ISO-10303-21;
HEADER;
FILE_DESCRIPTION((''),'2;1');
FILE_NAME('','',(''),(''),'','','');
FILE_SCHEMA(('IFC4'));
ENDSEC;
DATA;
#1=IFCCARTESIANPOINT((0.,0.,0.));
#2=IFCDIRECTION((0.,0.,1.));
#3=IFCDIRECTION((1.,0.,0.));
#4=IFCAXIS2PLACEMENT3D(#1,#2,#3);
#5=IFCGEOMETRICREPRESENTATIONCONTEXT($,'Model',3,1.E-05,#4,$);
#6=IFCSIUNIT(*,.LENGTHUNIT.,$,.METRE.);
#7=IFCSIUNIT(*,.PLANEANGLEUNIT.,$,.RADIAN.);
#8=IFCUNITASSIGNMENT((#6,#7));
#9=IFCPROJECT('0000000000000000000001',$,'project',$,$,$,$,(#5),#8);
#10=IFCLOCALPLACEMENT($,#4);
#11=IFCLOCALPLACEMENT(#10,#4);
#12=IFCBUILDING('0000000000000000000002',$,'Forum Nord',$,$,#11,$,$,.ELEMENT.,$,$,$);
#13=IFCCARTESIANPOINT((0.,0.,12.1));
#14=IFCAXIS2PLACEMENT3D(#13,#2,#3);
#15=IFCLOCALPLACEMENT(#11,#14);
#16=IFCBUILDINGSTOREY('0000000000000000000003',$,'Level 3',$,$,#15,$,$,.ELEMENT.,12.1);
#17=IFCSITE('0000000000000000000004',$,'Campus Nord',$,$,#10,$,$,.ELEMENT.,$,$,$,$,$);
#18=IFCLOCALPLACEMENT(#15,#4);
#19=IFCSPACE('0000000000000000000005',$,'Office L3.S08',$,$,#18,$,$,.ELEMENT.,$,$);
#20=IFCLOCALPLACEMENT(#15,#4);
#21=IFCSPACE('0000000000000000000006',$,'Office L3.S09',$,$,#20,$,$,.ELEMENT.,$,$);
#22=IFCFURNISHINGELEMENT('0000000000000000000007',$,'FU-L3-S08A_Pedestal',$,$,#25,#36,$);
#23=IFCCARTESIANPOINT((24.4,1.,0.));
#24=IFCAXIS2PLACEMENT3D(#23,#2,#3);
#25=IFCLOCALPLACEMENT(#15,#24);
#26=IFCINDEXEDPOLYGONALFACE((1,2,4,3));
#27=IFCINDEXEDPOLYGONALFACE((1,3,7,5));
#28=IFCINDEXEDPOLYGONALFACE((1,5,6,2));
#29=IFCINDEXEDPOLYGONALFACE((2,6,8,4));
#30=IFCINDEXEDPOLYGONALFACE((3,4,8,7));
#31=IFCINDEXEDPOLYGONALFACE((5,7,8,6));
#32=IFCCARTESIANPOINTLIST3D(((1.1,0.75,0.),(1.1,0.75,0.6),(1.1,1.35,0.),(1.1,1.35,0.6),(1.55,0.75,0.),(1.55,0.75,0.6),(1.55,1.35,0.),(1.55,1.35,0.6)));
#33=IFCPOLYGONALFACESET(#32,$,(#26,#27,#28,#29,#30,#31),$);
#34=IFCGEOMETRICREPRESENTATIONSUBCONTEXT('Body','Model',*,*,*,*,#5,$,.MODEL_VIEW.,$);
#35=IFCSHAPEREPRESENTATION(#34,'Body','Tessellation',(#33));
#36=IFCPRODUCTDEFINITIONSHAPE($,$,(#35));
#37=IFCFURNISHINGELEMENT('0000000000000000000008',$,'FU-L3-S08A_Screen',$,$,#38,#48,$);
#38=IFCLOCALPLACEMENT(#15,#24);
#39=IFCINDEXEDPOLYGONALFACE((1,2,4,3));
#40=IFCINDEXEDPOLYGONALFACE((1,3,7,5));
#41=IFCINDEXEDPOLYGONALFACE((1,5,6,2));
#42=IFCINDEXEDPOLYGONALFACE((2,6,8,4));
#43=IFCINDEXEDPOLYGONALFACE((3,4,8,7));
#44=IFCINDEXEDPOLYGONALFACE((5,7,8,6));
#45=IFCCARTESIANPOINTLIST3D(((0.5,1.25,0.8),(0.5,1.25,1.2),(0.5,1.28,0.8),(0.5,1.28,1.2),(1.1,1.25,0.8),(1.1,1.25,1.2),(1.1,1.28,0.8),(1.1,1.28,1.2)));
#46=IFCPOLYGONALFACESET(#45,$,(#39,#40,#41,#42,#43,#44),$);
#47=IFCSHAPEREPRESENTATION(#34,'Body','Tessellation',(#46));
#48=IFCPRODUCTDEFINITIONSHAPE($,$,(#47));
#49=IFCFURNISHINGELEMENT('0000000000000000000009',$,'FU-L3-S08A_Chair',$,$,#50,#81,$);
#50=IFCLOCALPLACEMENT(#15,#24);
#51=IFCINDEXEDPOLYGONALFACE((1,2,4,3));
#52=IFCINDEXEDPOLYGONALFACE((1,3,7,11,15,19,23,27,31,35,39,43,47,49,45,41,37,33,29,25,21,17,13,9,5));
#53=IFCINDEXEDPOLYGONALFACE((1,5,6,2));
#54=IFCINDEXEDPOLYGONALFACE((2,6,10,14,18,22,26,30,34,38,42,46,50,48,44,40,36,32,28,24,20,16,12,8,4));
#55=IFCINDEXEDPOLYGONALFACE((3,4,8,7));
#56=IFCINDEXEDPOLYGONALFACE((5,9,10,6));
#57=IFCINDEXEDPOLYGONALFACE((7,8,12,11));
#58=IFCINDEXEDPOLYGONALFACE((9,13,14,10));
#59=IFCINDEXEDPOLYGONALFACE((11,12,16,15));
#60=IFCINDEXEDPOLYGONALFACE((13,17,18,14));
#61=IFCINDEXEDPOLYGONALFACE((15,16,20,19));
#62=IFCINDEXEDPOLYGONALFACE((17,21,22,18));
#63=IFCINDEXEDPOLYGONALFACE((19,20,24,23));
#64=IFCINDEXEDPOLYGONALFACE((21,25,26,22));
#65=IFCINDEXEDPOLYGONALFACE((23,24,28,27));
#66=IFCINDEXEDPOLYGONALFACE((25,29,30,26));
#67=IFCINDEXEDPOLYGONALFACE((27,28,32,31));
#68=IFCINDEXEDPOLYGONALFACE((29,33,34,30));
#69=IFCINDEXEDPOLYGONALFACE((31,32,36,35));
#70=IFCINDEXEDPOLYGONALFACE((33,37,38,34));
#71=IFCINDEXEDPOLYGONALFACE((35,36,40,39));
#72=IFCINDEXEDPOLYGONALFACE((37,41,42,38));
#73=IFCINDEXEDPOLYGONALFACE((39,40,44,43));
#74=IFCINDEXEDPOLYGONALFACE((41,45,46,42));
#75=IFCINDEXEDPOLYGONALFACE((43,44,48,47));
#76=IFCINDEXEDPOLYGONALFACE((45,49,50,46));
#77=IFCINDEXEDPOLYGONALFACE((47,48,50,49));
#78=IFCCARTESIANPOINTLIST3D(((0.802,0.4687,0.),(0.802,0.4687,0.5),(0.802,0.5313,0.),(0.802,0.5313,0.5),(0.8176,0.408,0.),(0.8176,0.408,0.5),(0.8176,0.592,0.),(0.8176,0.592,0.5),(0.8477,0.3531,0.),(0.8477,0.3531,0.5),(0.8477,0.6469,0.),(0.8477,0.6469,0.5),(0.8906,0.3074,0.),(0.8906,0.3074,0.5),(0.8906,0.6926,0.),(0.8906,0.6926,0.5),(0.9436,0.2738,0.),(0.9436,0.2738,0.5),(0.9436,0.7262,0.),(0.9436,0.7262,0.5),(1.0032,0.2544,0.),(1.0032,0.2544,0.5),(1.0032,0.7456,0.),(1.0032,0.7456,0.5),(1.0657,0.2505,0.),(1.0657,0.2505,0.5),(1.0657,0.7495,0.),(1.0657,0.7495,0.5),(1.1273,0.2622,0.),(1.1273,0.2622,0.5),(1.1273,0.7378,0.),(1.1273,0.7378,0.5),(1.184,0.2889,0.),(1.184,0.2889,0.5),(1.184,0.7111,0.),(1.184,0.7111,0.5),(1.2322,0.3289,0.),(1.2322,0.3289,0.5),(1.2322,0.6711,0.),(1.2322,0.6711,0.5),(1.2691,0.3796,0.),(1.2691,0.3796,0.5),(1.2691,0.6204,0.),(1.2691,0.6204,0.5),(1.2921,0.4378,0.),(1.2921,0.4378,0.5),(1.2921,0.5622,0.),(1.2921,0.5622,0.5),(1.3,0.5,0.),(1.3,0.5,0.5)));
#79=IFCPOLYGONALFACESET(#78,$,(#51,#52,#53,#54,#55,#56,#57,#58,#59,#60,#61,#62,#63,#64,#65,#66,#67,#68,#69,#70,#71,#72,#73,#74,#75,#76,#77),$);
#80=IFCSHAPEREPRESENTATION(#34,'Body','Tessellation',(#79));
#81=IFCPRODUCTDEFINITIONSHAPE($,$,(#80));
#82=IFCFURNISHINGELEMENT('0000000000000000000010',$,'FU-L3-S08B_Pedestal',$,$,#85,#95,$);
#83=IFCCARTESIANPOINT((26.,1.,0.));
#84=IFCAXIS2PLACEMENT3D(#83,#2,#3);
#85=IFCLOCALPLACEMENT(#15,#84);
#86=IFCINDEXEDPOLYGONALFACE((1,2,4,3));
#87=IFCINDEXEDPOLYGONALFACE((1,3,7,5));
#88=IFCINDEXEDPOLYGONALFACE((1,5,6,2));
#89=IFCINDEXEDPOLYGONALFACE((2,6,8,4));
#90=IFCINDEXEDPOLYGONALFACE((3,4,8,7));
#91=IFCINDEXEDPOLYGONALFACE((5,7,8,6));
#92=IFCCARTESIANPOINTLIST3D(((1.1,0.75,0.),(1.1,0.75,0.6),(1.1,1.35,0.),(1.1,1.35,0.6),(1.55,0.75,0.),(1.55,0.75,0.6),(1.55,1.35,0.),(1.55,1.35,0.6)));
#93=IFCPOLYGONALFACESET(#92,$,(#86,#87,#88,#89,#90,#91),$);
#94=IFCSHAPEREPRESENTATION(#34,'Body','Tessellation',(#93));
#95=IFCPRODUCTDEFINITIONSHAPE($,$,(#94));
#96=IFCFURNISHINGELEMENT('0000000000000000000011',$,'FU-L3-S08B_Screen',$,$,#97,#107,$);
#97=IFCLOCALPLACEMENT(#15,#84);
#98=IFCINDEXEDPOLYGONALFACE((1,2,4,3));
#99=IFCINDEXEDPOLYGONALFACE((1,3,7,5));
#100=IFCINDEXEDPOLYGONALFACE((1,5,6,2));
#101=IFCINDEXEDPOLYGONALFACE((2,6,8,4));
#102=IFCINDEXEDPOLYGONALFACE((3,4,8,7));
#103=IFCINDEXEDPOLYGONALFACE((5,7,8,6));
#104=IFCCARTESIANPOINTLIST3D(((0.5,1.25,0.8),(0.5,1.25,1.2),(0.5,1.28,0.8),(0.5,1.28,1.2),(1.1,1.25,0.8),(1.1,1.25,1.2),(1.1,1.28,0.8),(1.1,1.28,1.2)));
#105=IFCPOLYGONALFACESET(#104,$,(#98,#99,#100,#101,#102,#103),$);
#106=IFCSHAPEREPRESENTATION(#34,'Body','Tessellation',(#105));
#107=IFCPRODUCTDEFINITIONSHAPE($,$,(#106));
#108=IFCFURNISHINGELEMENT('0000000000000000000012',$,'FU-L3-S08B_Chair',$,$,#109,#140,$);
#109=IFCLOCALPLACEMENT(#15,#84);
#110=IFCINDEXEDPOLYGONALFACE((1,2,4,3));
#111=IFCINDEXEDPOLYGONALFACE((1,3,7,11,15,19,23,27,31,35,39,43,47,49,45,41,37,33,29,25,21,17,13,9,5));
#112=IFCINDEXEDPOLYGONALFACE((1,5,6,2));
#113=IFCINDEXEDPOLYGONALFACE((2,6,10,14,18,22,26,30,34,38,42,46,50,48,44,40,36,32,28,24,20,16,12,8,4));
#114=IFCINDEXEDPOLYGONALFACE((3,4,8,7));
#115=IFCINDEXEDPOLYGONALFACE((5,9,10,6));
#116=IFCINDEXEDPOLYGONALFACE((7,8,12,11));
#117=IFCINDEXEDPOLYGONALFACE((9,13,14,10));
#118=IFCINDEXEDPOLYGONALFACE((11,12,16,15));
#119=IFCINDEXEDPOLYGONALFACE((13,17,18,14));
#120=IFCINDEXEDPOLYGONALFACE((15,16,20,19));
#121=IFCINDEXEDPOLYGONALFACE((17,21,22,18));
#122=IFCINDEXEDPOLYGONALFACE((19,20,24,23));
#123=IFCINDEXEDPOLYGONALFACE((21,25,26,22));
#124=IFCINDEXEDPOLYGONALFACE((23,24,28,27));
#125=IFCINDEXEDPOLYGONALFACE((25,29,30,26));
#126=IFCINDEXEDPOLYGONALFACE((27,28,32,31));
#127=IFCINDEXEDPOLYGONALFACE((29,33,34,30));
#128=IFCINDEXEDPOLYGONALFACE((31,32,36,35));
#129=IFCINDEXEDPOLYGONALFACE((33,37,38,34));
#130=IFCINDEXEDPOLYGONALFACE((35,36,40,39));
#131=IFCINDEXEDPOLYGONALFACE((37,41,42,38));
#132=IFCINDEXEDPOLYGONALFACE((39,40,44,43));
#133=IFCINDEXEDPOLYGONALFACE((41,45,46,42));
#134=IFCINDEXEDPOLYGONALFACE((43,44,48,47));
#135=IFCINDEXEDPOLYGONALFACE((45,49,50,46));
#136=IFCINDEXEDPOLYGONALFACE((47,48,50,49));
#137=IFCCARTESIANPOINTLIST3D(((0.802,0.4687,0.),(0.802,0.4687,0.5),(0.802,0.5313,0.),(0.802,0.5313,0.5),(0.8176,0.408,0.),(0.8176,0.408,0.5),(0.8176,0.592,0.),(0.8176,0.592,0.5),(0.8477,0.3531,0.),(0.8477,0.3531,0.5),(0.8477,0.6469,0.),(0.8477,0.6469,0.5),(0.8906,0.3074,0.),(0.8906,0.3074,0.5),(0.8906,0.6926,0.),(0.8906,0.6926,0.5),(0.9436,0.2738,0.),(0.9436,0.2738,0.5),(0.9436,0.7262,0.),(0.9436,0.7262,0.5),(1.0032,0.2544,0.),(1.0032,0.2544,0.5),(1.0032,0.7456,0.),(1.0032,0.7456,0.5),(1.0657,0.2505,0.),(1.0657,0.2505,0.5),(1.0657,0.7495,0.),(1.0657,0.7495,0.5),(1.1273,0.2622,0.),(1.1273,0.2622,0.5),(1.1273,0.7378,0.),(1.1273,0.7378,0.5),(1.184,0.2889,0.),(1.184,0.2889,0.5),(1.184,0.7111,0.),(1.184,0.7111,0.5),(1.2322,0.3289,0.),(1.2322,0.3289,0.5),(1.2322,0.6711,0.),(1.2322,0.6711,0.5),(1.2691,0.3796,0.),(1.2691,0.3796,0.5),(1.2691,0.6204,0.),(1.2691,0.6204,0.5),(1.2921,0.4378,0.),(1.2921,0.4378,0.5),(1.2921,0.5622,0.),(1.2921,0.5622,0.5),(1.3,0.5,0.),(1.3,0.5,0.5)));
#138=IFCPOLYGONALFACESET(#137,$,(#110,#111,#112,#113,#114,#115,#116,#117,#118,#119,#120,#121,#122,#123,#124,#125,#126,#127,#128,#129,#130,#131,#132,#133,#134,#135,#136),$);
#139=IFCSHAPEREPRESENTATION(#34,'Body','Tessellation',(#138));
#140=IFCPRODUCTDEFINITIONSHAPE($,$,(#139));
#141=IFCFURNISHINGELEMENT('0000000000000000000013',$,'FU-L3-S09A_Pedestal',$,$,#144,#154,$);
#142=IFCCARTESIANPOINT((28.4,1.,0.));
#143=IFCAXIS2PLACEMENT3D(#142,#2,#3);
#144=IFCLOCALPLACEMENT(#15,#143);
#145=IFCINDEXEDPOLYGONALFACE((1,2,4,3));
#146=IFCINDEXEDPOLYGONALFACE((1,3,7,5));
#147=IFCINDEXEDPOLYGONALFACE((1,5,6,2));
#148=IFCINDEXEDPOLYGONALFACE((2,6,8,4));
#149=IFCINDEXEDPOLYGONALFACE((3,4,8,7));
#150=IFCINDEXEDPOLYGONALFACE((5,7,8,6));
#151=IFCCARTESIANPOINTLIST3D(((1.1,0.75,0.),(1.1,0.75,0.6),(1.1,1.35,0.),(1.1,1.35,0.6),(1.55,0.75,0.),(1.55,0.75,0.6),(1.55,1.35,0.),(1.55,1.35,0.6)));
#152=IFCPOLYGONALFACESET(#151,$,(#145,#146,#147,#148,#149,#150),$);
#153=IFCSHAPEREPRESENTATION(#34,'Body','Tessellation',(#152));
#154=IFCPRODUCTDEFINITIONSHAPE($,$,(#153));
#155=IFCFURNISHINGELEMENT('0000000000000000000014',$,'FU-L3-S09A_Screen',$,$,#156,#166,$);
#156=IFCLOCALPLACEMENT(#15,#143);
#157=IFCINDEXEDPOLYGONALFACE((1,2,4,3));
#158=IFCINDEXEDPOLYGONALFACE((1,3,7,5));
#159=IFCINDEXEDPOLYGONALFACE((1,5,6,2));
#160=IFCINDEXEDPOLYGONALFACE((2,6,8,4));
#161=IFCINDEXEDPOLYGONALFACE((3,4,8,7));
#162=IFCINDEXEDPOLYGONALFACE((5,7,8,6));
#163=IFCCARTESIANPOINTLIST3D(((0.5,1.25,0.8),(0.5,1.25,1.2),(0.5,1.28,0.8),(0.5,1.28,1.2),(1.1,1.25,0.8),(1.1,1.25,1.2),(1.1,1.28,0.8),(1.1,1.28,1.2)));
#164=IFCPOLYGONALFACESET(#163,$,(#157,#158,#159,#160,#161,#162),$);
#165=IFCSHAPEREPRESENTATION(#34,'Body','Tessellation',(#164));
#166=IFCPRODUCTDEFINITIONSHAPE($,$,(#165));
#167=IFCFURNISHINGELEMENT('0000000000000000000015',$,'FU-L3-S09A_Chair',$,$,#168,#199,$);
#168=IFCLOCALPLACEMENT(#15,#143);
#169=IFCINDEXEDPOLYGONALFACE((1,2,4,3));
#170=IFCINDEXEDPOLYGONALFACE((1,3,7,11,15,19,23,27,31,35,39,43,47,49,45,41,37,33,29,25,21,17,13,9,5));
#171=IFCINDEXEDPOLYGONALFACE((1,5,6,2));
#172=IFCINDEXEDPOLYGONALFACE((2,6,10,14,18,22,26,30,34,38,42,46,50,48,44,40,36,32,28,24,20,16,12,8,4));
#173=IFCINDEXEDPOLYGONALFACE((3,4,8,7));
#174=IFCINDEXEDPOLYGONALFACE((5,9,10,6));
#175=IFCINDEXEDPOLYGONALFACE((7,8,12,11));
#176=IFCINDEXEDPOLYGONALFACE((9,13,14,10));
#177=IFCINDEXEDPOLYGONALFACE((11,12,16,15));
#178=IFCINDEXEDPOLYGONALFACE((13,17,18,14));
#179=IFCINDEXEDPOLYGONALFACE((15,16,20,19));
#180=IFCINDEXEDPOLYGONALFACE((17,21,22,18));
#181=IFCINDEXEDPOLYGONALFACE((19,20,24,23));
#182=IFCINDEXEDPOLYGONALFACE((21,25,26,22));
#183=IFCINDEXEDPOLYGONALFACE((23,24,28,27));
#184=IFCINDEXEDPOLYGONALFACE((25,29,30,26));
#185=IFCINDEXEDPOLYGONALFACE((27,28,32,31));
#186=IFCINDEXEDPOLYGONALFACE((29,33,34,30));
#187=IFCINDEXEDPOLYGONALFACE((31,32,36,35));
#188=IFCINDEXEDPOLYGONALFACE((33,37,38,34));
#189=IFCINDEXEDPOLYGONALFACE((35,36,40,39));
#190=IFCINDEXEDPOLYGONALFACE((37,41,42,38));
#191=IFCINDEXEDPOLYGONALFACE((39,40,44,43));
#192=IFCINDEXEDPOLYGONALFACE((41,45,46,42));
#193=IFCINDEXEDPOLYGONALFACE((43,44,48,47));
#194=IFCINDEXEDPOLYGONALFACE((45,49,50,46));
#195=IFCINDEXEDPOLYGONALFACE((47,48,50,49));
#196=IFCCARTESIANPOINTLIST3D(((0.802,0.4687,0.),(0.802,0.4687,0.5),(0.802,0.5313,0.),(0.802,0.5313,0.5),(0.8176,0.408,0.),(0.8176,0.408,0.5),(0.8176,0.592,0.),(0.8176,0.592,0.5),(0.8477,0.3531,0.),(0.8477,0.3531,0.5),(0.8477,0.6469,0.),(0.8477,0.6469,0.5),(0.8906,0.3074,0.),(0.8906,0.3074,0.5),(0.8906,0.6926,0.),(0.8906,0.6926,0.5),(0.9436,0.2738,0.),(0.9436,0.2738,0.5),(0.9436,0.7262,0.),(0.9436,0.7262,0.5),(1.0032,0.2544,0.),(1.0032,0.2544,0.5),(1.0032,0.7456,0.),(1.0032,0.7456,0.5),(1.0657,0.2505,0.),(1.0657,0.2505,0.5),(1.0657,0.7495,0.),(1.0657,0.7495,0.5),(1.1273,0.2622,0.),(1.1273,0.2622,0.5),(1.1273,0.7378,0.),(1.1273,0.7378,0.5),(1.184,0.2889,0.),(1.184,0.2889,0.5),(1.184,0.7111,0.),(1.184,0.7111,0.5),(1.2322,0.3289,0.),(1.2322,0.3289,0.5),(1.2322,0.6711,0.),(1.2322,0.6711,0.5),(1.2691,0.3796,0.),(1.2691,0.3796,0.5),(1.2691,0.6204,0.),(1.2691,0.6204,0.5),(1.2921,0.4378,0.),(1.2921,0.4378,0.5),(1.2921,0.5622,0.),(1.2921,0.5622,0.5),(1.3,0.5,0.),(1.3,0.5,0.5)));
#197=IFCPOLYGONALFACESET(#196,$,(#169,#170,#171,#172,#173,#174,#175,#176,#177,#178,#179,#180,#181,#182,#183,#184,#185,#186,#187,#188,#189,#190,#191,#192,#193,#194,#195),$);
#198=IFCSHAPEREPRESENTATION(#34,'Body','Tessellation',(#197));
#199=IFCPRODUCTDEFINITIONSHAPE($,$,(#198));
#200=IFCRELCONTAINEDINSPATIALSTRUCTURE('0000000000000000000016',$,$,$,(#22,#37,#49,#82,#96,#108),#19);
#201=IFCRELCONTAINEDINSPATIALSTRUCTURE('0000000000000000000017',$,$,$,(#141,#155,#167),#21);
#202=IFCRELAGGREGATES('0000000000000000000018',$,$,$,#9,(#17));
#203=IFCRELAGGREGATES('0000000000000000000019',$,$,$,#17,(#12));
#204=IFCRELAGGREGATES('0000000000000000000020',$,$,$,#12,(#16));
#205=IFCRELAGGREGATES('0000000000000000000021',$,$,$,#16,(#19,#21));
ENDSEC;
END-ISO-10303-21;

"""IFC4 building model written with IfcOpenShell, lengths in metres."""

from ifc_helpers import new_model, si_unit, frame, frame_2d, origin_with_axes, place, context, subcontext, project, spatial, rectangle, circle, extrude, element, save


model = new_model("IFC4")

# Units and contexts
model_context = context("Model", 3, precision=1e-05, world=origin_with_axes())
body_context = subcontext(model_context, "Body", "Model", "MODEL_VIEW")
ifc_project = project(units=[si_unit("LENGTHUNIT", "METRE"), si_unit("PLANEANGLEUNIT", "RADIAN")], contexts=[model_context])

# Site, building, storey
site_placement = place(None, origin_with_axes())
site = spatial("IfcSite", under=ifc_project, at=site_placement, Name="Campus Nord", CompositionType="ELEMENT")
building_placement = place(site_placement, origin_with_axes())
building = spatial("IfcBuilding", under=site, at=building_placement, Name="Forum Nord", CompositionType="ELEMENT")
storey_placement = place(building_placement, frame((0.0, 0.0, 12.1), z_axis=(0.0, 0.0, 1.0), x_axis=(1.0, 0.0, 0.0)))
storey = spatial("IfcBuildingStorey", under=building, at=storey_placement, Name="Level 3", CompositionType="ELEMENT", Elevation=12.1)

# Shared definitions
space_1_placement = place(storey_placement, origin_with_axes())
space_1 = spatial("IfcSpace", under=storey, at=space_1_placement, Name="Office L3.S08", CompositionType="ELEMENT")

# Furnishing elements
furnishing_1_placement = place(storey_placement, frame((24.4, 1.0, 0.0), z_axis=(0.0, 0.0, 1.0), x_axis=(1.0, 0.0, 0.0)))
element("IfcFurnishingElement", 1, at=furnishing_1_placement, inside=space_1, Name="FU-L3-S08A_Pedestal", context=body_context, shape_type="SweptSolid", body=[
    extrude(rectangle(XDim=0.45, YDim=0.6, at=frame_2d((1.325, 1.05), x_axis=(1.0, 0.0))), origin_with_axes(), (0.0, 0.0, 1.0), 0.6),
])
furnishing_2_placement = place(storey_placement, frame((24.4, 1.0, 0.0), z_axis=(0.0, 0.0, 1.0), x_axis=(1.0, 0.0, 0.0)))
element("IfcFurnishingElement", 2, at=furnishing_2_placement, inside=space_1, Name="FU-L3-S08A_Screen", context=body_context, shape_type="SweptSolid", body=[
    extrude(rectangle(XDim=0.6, YDim=0.03, at=frame_2d((0.8, 1.265), x_axis=(1.0, 0.0))), frame((0.0, 0.0, 0.8), z_axis=(0.0, 0.0, 1.0), x_axis=(1.0, 0.0, 0.0)), (0.0, 0.0, 1.0), 0.4),
])
furnishing_3_placement = place(storey_placement, frame((24.4, 1.0, 0.0), z_axis=(0.0, 0.0, 1.0), x_axis=(1.0, 0.0, 0.0)))
element("IfcFurnishingElement", 3, at=furnishing_3_placement, inside=space_1, Name="FU-L3-S08A_Chair", context=body_context, shape_type="SweptSolid", body=[
    extrude(circle(Radius=0.25, at=frame_2d((1.05, 0.5), x_axis=(1.0, 0.0))), origin_with_axes(), (0.0, 0.0, 1.0), 0.5),
])
furnishing_4_placement = place(storey_placement, frame((26.0, 1.0, 0.0), z_axis=(0.0, 0.0, 1.0), x_axis=(1.0, 0.0, 0.0)))
element("IfcFurnishingElement", 4, at=furnishing_4_placement, inside=space_1, Name="FU-L3-S08B_Pedestal", context=body_context, shape_type="SweptSolid", body=[
    extrude(rectangle(XDim=0.45, YDim=0.6, at=frame_2d((1.325, 1.05), x_axis=(1.0, 0.0))), origin_with_axes(), (0.0, 0.0, 1.0), 0.6),
])
furnishing_5_placement = place(storey_placement, frame((26.0, 1.0, 0.0), z_axis=(0.0, 0.0, 1.0), x_axis=(1.0, 0.0, 0.0)))
element("IfcFurnishingElement", 5, at=furnishing_5_placement, inside=space_1, Name="FU-L3-S08B_Screen", context=body_context, shape_type="SweptSolid", body=[
    extrude(rectangle(XDim=0.6, YDim=0.03, at=frame_2d((0.8, 1.265), x_axis=(1.0, 0.0))), frame((0.0, 0.0, 0.8), z_axis=(0.0, 0.0, 1.0), x_axis=(1.0, 0.0, 0.0)), (0.0, 0.0, 1.0), 0.4),
])
furnishing_6_placement = place(storey_placement, frame((26.0, 1.0, 0.0), z_axis=(0.0, 0.0, 1.0), x_axis=(1.0, 0.0, 0.0)))
element("IfcFurnishingElement", 6, at=furnishing_6_placement, inside=space_1, Name="FU-L3-S08B_Chair", context=body_context, shape_type="SweptSolid", body=[
    extrude(circle(Radius=0.25, at=frame_2d((1.05, 0.5), x_axis=(1.0, 0.0))), origin_with_axes(), (0.0, 0.0, 1.0), 0.5),
])

# Shared definitions
space_2_placement = place(storey_placement, origin_with_axes())
space_2 = spatial("IfcSpace", under=storey, at=space_2_placement, Name="Office L3.S09", CompositionType="ELEMENT")

# Furnishing elements
furnishing_7_placement = place(storey_placement, frame((28.4, 1.0, 0.0), z_axis=(0.0, 0.0, 1.0), x_axis=(1.0, 0.0, 0.0)))
element("IfcFurnishingElement", 7, at=furnishing_7_placement, inside=space_2, Name="FU-L3-S09A_Pedestal", context=body_context, shape_type="SweptSolid", body=[
    extrude(rectangle(XDim=0.45, YDim=0.6, at=frame_2d((1.325, 1.05), x_axis=(1.0, 0.0))), origin_with_axes(), (0.0, 0.0, 1.0), 0.6),
])
furnishing_8_placement = place(storey_placement, frame((28.4, 1.0, 0.0), z_axis=(0.0, 0.0, 1.0), x_axis=(1.0, 0.0, 0.0)))
element("IfcFurnishingElement", 8, at=furnishing_8_placement, inside=space_2, Name="FU-L3-S09A_Screen", context=body_context, shape_type="SweptSolid", body=[
    extrude(rectangle(XDim=0.6, YDim=0.03, at=frame_2d((0.8, 1.265), x_axis=(1.0, 0.0))), frame((0.0, 0.0, 0.8), z_axis=(0.0, 0.0, 1.0), x_axis=(1.0, 0.0, 0.0)), (0.0, 0.0, 1.0), 0.4),
])
furnishing_9_placement = place(storey_placement, frame((28.4, 1.0, 0.0), z_axis=(0.0, 0.0, 1.0), x_axis=(1.0, 0.0, 0.0)))
element("IfcFurnishingElement", 9, at=furnishing_9_placement, inside=space_2, Name="FU-L3-S09A_Chair", context=body_context, shape_type="SweptSolid", body=[
    extrude(circle(Radius=0.25, at=frame_2d((1.05, 0.5), x_axis=(1.0, 0.0))), origin_with_axes(), (0.0, 0.0, 1.0), 0.5),
])

save(model, "model.ifc")
